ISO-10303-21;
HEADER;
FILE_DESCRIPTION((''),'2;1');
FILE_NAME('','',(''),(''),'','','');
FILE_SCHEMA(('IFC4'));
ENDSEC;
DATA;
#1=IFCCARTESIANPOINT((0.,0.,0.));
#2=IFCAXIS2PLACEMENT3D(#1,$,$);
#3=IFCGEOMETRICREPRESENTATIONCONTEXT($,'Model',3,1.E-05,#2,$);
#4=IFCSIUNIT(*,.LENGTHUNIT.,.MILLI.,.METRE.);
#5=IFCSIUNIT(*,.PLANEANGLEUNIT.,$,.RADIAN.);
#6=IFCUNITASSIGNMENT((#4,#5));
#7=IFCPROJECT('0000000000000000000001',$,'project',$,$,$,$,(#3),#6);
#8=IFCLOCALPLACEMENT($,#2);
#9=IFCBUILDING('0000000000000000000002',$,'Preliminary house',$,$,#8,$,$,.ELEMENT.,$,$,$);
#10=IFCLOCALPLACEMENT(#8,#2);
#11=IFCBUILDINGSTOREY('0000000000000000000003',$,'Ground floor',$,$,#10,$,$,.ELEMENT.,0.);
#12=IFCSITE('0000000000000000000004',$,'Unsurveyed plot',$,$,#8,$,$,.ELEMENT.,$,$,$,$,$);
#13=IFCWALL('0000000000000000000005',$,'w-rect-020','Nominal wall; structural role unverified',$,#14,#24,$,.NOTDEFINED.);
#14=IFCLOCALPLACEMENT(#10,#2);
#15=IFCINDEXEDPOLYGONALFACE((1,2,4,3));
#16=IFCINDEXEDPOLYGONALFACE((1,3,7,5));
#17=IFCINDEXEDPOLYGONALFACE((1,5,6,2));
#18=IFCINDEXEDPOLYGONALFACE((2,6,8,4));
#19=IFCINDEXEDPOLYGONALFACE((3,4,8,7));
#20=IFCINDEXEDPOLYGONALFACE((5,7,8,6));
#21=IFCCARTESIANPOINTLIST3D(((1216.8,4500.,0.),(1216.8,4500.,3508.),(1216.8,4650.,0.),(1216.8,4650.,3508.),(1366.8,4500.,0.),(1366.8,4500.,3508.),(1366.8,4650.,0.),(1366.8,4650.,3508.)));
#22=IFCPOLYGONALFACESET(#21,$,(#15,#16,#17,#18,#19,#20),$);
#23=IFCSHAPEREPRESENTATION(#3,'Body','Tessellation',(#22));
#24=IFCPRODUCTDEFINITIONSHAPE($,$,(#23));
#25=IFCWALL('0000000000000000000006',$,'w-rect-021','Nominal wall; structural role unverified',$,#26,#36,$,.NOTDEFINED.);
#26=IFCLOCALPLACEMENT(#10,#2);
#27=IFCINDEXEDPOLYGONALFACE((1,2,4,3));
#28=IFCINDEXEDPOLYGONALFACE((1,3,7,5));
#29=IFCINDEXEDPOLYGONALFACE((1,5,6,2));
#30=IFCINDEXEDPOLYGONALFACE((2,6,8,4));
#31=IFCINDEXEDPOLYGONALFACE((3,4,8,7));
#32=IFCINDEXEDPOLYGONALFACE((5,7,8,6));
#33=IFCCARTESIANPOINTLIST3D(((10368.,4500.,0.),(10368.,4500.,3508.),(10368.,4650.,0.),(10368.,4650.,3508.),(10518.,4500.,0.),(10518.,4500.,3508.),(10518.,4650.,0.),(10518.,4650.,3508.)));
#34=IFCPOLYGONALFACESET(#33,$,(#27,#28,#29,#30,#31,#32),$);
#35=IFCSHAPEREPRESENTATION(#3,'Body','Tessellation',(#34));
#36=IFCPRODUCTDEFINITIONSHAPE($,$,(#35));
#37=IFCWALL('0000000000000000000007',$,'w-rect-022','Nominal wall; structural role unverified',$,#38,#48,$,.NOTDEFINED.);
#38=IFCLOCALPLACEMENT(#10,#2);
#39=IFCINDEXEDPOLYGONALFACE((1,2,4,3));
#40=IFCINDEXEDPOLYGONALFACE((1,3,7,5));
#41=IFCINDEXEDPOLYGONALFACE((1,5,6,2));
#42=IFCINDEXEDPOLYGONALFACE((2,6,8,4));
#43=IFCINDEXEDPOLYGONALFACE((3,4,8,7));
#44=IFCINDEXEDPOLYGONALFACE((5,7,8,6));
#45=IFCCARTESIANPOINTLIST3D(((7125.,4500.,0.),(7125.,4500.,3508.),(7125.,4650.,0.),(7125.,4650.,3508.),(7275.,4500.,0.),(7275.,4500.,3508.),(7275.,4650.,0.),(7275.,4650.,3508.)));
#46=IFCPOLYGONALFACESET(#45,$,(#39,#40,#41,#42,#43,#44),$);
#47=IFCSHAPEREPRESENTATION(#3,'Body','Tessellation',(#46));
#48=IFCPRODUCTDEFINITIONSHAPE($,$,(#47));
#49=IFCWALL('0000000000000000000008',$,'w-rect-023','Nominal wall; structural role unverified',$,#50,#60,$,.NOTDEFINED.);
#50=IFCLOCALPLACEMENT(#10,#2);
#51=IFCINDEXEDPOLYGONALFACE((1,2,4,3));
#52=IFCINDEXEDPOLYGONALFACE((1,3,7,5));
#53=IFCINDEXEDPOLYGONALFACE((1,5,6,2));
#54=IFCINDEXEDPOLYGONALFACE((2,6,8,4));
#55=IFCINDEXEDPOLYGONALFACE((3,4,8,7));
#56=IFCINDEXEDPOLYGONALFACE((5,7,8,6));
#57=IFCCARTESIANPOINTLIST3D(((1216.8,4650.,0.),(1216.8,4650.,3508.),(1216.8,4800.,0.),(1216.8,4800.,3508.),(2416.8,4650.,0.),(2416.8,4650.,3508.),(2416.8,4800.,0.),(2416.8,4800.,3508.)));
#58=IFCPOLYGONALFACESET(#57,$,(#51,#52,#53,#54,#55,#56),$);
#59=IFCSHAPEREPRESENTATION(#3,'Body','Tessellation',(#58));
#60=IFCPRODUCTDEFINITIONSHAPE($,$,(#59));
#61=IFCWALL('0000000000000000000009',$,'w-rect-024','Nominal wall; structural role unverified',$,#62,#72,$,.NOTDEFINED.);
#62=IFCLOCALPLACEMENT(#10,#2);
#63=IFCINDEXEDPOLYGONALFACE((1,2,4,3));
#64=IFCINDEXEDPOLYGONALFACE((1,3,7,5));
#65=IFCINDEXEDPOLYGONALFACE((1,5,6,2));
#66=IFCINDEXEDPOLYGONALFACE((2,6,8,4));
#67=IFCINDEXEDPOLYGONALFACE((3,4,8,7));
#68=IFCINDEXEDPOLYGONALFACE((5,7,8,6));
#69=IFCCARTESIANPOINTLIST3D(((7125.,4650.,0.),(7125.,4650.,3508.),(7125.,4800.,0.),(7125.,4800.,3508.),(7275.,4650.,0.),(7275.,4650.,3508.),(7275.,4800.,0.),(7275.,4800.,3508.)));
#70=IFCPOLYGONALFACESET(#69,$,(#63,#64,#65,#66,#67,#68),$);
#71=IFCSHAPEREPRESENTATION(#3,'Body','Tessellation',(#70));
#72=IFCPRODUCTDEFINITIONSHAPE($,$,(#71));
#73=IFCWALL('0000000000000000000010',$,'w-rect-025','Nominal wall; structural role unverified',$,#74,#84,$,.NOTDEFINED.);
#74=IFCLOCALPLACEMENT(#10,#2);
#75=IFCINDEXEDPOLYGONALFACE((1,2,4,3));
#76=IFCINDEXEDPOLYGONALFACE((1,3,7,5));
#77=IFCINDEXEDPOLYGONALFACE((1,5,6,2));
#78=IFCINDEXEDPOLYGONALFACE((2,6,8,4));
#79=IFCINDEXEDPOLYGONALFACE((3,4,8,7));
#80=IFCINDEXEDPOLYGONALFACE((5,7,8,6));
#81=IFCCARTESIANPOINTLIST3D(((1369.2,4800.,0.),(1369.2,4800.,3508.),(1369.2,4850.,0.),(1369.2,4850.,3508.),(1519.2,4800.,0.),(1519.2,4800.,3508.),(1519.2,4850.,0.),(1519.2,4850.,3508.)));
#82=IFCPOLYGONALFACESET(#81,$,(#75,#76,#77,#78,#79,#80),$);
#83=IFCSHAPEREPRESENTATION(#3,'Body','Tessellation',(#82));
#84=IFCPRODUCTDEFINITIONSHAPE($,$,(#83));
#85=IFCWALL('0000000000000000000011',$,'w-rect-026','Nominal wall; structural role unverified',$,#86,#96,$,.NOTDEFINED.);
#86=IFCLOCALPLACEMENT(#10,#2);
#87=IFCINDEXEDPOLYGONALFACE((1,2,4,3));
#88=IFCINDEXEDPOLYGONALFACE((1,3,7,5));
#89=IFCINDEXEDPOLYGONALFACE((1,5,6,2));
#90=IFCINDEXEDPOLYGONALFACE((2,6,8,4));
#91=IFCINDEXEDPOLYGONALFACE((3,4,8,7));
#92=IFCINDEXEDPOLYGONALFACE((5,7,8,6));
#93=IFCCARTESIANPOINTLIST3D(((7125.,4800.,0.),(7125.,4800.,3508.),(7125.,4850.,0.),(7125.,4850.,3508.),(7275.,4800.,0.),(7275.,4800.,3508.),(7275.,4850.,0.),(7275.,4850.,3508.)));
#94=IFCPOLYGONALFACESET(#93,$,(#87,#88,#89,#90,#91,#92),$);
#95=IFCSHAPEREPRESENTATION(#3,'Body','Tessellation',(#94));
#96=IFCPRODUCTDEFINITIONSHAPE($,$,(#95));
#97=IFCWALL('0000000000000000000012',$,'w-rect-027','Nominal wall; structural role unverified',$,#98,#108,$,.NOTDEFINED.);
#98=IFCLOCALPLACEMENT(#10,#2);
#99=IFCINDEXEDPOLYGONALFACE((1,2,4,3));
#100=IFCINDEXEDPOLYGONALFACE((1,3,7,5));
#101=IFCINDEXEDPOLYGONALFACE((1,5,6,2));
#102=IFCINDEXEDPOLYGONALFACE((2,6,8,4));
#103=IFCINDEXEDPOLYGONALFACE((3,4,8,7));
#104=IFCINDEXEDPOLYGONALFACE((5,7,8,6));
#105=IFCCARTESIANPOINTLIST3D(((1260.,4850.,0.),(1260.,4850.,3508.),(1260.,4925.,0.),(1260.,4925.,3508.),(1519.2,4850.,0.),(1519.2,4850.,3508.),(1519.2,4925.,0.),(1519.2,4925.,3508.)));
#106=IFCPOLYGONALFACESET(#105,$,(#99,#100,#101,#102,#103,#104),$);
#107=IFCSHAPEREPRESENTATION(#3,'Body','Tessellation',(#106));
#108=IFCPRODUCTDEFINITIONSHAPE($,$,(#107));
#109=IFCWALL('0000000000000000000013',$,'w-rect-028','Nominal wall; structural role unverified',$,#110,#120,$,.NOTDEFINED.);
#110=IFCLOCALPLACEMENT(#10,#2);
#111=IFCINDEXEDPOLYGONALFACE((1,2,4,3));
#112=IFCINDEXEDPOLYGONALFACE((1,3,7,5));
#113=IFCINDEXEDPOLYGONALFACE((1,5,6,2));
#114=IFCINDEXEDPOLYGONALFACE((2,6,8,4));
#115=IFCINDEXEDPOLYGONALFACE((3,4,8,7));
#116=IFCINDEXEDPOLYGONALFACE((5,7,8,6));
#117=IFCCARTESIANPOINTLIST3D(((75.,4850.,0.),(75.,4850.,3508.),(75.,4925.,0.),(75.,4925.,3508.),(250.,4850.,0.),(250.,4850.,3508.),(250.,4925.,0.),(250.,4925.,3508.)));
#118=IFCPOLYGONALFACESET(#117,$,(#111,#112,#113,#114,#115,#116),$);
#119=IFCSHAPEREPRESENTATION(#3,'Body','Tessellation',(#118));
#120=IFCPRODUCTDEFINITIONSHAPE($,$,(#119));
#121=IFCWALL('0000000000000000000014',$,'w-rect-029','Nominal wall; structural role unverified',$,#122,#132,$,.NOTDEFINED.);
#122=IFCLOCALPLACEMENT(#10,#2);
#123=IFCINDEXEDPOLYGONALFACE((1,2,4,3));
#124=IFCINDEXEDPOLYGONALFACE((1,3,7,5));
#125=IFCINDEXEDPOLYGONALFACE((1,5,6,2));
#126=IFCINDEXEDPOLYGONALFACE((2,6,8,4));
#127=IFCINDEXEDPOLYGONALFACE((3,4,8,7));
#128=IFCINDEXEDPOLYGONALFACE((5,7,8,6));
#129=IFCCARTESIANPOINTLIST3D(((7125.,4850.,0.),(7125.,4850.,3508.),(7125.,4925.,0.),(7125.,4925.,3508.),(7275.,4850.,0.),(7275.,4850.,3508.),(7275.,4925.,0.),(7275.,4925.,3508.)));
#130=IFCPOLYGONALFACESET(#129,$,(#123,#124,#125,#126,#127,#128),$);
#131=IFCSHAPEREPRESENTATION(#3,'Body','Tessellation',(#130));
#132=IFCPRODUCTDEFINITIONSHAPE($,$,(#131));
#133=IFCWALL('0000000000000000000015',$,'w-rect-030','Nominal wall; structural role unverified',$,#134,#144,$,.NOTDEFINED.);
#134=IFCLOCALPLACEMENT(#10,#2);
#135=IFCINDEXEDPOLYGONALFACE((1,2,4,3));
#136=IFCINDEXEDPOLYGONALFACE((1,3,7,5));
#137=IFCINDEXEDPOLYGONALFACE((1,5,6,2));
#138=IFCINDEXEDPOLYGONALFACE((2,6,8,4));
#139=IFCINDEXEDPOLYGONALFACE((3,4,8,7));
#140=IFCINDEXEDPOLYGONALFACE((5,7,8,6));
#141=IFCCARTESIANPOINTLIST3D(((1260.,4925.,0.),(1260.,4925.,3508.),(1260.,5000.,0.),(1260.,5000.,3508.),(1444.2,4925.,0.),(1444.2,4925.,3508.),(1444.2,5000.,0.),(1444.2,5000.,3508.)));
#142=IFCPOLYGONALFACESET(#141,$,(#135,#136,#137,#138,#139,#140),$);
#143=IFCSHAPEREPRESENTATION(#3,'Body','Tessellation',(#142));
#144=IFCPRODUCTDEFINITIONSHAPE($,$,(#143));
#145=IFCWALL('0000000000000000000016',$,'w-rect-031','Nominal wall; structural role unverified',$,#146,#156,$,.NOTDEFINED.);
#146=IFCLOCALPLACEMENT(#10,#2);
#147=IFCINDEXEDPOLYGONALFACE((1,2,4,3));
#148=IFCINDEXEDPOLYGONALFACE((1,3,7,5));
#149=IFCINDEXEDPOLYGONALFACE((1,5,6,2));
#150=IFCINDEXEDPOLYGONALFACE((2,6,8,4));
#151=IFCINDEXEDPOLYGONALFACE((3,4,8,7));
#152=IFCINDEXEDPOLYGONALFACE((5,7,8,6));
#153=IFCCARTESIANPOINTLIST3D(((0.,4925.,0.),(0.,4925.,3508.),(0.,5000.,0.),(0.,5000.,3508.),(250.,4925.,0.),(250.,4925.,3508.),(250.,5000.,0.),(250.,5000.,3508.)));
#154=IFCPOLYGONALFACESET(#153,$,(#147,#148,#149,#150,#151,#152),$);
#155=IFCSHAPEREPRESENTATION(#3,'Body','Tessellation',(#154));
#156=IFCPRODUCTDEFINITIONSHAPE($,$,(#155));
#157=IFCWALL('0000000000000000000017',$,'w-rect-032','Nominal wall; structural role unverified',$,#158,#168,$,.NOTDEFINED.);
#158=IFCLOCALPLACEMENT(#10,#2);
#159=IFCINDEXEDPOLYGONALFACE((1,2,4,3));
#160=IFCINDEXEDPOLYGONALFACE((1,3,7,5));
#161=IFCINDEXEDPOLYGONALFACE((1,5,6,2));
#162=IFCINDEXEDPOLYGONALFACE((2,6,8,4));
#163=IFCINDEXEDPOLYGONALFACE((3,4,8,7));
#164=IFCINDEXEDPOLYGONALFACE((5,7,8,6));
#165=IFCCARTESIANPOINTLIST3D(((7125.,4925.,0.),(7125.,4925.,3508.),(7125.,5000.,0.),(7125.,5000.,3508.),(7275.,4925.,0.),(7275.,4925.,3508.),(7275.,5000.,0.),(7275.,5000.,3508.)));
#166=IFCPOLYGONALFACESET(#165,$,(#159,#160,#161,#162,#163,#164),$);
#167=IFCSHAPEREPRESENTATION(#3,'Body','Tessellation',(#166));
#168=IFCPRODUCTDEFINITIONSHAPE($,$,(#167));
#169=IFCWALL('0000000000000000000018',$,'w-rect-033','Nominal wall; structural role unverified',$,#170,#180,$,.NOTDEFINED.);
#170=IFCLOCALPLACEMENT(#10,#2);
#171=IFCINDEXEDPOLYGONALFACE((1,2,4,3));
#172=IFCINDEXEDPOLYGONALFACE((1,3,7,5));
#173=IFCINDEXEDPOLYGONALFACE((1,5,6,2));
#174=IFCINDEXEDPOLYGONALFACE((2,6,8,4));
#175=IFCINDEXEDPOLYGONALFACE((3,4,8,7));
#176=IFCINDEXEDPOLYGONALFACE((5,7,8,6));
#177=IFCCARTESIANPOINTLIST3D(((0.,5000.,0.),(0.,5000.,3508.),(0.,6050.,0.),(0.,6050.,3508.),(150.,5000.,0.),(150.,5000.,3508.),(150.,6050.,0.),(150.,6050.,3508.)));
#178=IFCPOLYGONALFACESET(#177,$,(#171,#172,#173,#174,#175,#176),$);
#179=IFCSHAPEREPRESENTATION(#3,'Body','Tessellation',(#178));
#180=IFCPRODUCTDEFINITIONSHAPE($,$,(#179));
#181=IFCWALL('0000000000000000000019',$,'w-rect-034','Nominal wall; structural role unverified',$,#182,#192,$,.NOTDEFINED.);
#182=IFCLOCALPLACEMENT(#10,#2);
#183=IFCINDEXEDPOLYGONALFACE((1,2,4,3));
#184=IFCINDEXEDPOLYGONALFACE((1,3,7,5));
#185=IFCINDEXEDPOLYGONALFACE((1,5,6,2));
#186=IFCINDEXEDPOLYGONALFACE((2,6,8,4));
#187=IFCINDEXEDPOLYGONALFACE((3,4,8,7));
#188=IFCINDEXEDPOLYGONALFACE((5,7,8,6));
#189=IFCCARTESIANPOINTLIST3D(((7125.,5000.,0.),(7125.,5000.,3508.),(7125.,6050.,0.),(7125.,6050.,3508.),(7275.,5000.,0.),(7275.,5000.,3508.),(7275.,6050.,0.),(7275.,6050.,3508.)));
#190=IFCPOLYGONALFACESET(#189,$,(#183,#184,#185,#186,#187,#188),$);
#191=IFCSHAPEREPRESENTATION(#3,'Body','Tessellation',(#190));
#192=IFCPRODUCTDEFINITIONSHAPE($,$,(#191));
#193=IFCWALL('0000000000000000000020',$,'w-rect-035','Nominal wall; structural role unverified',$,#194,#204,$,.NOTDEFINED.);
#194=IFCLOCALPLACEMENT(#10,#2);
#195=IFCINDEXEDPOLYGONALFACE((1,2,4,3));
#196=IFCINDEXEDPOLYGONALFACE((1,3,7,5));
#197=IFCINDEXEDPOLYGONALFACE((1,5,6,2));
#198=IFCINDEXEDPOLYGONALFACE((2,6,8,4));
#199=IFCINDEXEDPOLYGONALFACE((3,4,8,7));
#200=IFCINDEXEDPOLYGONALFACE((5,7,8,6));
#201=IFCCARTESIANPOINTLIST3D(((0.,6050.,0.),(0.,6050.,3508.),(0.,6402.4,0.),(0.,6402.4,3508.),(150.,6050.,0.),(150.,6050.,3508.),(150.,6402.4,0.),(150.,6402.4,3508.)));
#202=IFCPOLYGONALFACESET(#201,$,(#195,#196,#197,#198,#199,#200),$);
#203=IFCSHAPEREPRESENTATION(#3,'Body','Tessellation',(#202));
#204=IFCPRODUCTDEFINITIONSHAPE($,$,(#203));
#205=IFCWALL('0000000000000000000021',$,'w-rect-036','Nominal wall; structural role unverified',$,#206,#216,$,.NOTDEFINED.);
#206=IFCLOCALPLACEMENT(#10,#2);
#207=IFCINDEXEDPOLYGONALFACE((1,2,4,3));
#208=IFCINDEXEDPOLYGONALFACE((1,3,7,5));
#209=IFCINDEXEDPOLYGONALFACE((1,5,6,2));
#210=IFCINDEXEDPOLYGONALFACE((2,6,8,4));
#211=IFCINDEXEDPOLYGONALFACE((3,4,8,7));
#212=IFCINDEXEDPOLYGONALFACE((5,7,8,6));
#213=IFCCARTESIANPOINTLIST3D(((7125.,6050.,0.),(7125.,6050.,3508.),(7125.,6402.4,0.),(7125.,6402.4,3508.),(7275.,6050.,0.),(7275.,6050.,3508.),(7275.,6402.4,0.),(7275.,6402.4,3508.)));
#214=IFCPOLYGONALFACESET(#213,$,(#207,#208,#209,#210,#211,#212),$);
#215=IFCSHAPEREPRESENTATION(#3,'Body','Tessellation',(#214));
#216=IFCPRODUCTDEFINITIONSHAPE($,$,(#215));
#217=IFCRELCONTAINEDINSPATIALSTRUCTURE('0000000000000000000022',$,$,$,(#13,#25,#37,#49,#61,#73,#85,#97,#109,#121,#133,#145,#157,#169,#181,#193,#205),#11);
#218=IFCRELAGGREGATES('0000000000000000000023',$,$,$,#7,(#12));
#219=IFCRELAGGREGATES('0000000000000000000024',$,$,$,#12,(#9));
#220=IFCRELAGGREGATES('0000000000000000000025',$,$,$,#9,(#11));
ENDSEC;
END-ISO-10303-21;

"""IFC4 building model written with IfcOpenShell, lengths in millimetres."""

from ifc_helpers import new_model, si_unit, origin, place, context, project, spatial, polyline, outline, extrude, element, save


model = new_model("IFC4")

# Units and contexts
model_context = context("Model", 3, precision=1e-05, world=origin())
ifc_project = project(units=[si_unit("LENGTHUNIT", "METRE", prefix="MILLI"), si_unit("PLANEANGLEUNIT", "RADIAN")], contexts=[model_context])

# Site, building, storey
placement_1 = place(None, origin())
site = spatial("IfcSite", under=ifc_project, at=placement_1, Name="Unsurveyed plot", CompositionType="ELEMENT")
building = spatial("IfcBuilding", under=site, at=placement_1, Name="Preliminary house", CompositionType="ELEMENT")
placement_2 = place(placement_1, origin())
storey = spatial("IfcBuildingStorey", under=building, at=placement_2, Name="Ground floor", CompositionType="ELEMENT", Elevation=0.0)

# Walls
element("IfcWall", 1, at=placement_2, inside=storey, Name="w-rect-020", Description="Nominal wall; structural role unverified", PredefinedType="NOTDEFINED", context=model_context, shape_type="SweptSolid", body=[
    extrude(outline(polyline([(1216.8, 4500.0), (1366.8, 4500.0), (1366.8, 4650.0), (1216.8, 4650.0), (1216.8, 4500.0)])), origin(), (0.0, 0.0, 1.0), 3508.0),
])
element("IfcWall", 2, at=placement_2, inside=storey, Name="w-rect-021", Description="Nominal wall; structural role unverified", PredefinedType="NOTDEFINED", context=model_context, shape_type="SweptSolid", body=[
    extrude(outline(polyline([(10368.0, 4500.0), (10518.0, 4500.0), (10518.0, 4650.0), (10368.0, 4650.0), (10368.0, 4500.0)])), origin(), (0.0, 0.0, 1.0), 3508.0),
])
element("IfcWall", 3, at=placement_2, inside=storey, Name="w-rect-022", Description="Nominal wall; structural role unverified", PredefinedType="NOTDEFINED", context=model_context, shape_type="SweptSolid", body=[
    extrude(outline(polyline([(7125.0, 4500.0), (7275.0, 4500.0), (7275.0, 4650.0), (7125.0, 4650.0), (7125.0, 4500.0)])), origin(), (0.0, 0.0, 1.0), 3508.0),
])
element("IfcWall", 4, at=placement_2, inside=storey, Name="w-rect-023", Description="Nominal wall; structural role unverified", PredefinedType="NOTDEFINED", context=model_context, shape_type="SweptSolid", body=[
    extrude(outline(polyline([(1216.8, 4650.0), (2416.8, 4650.0), (2416.8, 4800.0), (1216.8, 4800.0), (1216.8, 4650.0)])), origin(), (0.0, 0.0, 1.0), 3508.0),
])
element("IfcWall", 5, at=placement_2, inside=storey, Name="w-rect-024", Description="Nominal wall; structural role unverified", PredefinedType="NOTDEFINED", context=model_context, shape_type="SweptSolid", body=[
    extrude(outline(polyline([(7125.0, 4650.0), (7275.0, 4650.0), (7275.0, 4800.0), (7125.0, 4800.0), (7125.0, 4650.0)])), origin(), (0.0, 0.0, 1.0), 3508.0),
])
element("IfcWall", 6, at=placement_2, inside=storey, Name="w-rect-025", Description="Nominal wall; structural role unverified", PredefinedType="NOTDEFINED", context=model_context, shape_type="SweptSolid", body=[
    extrude(outline(polyline([(1369.2, 4800.0), (1519.2, 4800.0), (1519.2, 4850.0), (1369.2, 4850.0), (1369.2, 4800.0)])), origin(), (0.0, 0.0, 1.0), 3508.0),
])
element("IfcWall", 7, at=placement_2, inside=storey, Name="w-rect-026", Description="Nominal wall; structural role unverified", PredefinedType="NOTDEFINED", context=model_context, shape_type="SweptSolid", body=[
    extrude(outline(polyline([(7125.0, 4800.0), (7275.0, 4800.0), (7275.0, 4850.0), (7125.0, 4850.0), (7125.0, 4800.0)])), origin(), (0.0, 0.0, 1.0), 3508.0),
])
element("IfcWall", 8, at=placement_2, inside=storey, Name="w-rect-027", Description="Nominal wall; structural role unverified", PredefinedType="NOTDEFINED", context=model_context, shape_type="SweptSolid", body=[
    extrude(outline(polyline([(1260.0, 4850.0), (1519.2, 4850.0), (1519.2, 4925.0), (1260.0, 4925.0), (1260.0, 4850.0)])), origin(), (0.0, 0.0, 1.0), 3508.0),
])
element("IfcWall", 9, at=placement_2, inside=storey, Name="w-rect-028", Description="Nominal wall; structural role unverified", PredefinedType="NOTDEFINED", context=model_context, shape_type="SweptSolid", body=[
    extrude(outline(polyline([(75.0, 4850.0), (250.0, 4850.0), (250.0, 4925.0), (75.0, 4925.0), (75.0, 4850.0)])), origin(), (0.0, 0.0, 1.0), 3508.0),
])
element("IfcWall", 10, at=placement_2, inside=storey, Name="w-rect-029", Description="Nominal wall; structural role unverified", PredefinedType="NOTDEFINED", context=model_context, shape_type="SweptSolid", body=[
    extrude(outline(polyline([(7125.0, 4850.0), (7275.0, 4850.0), (7275.0, 4925.0), (7125.0, 4925.0), (7125.0, 4850.0)])), origin(), (0.0, 0.0, 1.0), 3508.0),
])
element("IfcWall", 11, at=placement_2, inside=storey, Name="w-rect-030", Description="Nominal wall; structural role unverified", PredefinedType="NOTDEFINED", context=model_context, shape_type="SweptSolid", body=[
    extrude(outline(polyline([(1260.0, 4925.0), (1444.2, 4925.0), (1444.2, 5000.0), (1260.0, 5000.0), (1260.0, 4925.0)])), origin(), (0.0, 0.0, 1.0), 3508.0),
])
element("IfcWall", 12, at=placement_2, inside=storey, Name="w-rect-031", Description="Nominal wall; structural role unverified", PredefinedType="NOTDEFINED", context=model_context, shape_type="SweptSolid", body=[
    extrude(outline(polyline([(0.0, 4925.0), (250.0, 4925.0), (250.0, 5000.0), (0.0, 5000.0), (0.0, 4925.0)])), origin(), (0.0, 0.0, 1.0), 3508.0),
])
element("IfcWall", 13, at=placement_2, inside=storey, Name="w-rect-032", Description="Nominal wall; structural role unverified", PredefinedType="NOTDEFINED", context=model_context, shape_type="SweptSolid", body=[
    extrude(outline(polyline([(7125.0, 4925.0), (7275.0, 4925.0), (7275.0, 5000.0), (7125.0, 5000.0), (7125.0, 4925.0)])), origin(), (0.0, 0.0, 1.0), 3508.0),
])
element("IfcWall", 14, at=placement_2, inside=storey, Name="w-rect-033", Description="Nominal wall; structural role unverified", PredefinedType="NOTDEFINED", context=model_context, shape_type="SweptSolid", body=[
    extrude(outline(polyline([(0.0, 5000.0), (150.0, 5000.0), (150.0, 6050.0), (0.0, 6050.0), (0.0, 5000.0)])), origin(), (0.0, 0.0, 1.0), 3508.0),
])
element("IfcWall", 15, at=placement_2, inside=storey, Name="w-rect-034", Description="Nominal wall; structural role unverified", PredefinedType="NOTDEFINED", context=model_context, shape_type="SweptSolid", body=[
    extrude(outline(polyline([(7125.0, 5000.0), (7275.0, 5000.0), (7275.0, 6050.0), (7125.0, 6050.0), (7125.0, 5000.0)])), origin(), (0.0, 0.0, 1.0), 3508.0),
])
element("IfcWall", 16, at=placement_2, inside=storey, Name="w-rect-035", Description="Nominal wall; structural role unverified", PredefinedType="NOTDEFINED", context=model_context, shape_type="SweptSolid", body=[
    extrude(outline(polyline([(0.0, 6050.0), (150.0, 6050.0), (150.0, 6402.4), (0.0, 6402.4), (0.0, 6050.0)])), origin(), (0.0, 0.0, 1.0), 3508.0),
])
element("IfcWall", 17, at=placement_2, inside=storey, Name="w-rect-036", Description="Nominal wall; structural role unverified", PredefinedType="NOTDEFINED", context=model_context, shape_type="SweptSolid", body=[
    extrude(outline(polyline([(7125.0, 6050.0), (7275.0, 6050.0), (7275.0, 6402.4), (7125.0, 6402.4), (7125.0, 6050.0)])), origin(), (0.0, 0.0, 1.0), 3508.0),
])

save(model, "model.ifc")
